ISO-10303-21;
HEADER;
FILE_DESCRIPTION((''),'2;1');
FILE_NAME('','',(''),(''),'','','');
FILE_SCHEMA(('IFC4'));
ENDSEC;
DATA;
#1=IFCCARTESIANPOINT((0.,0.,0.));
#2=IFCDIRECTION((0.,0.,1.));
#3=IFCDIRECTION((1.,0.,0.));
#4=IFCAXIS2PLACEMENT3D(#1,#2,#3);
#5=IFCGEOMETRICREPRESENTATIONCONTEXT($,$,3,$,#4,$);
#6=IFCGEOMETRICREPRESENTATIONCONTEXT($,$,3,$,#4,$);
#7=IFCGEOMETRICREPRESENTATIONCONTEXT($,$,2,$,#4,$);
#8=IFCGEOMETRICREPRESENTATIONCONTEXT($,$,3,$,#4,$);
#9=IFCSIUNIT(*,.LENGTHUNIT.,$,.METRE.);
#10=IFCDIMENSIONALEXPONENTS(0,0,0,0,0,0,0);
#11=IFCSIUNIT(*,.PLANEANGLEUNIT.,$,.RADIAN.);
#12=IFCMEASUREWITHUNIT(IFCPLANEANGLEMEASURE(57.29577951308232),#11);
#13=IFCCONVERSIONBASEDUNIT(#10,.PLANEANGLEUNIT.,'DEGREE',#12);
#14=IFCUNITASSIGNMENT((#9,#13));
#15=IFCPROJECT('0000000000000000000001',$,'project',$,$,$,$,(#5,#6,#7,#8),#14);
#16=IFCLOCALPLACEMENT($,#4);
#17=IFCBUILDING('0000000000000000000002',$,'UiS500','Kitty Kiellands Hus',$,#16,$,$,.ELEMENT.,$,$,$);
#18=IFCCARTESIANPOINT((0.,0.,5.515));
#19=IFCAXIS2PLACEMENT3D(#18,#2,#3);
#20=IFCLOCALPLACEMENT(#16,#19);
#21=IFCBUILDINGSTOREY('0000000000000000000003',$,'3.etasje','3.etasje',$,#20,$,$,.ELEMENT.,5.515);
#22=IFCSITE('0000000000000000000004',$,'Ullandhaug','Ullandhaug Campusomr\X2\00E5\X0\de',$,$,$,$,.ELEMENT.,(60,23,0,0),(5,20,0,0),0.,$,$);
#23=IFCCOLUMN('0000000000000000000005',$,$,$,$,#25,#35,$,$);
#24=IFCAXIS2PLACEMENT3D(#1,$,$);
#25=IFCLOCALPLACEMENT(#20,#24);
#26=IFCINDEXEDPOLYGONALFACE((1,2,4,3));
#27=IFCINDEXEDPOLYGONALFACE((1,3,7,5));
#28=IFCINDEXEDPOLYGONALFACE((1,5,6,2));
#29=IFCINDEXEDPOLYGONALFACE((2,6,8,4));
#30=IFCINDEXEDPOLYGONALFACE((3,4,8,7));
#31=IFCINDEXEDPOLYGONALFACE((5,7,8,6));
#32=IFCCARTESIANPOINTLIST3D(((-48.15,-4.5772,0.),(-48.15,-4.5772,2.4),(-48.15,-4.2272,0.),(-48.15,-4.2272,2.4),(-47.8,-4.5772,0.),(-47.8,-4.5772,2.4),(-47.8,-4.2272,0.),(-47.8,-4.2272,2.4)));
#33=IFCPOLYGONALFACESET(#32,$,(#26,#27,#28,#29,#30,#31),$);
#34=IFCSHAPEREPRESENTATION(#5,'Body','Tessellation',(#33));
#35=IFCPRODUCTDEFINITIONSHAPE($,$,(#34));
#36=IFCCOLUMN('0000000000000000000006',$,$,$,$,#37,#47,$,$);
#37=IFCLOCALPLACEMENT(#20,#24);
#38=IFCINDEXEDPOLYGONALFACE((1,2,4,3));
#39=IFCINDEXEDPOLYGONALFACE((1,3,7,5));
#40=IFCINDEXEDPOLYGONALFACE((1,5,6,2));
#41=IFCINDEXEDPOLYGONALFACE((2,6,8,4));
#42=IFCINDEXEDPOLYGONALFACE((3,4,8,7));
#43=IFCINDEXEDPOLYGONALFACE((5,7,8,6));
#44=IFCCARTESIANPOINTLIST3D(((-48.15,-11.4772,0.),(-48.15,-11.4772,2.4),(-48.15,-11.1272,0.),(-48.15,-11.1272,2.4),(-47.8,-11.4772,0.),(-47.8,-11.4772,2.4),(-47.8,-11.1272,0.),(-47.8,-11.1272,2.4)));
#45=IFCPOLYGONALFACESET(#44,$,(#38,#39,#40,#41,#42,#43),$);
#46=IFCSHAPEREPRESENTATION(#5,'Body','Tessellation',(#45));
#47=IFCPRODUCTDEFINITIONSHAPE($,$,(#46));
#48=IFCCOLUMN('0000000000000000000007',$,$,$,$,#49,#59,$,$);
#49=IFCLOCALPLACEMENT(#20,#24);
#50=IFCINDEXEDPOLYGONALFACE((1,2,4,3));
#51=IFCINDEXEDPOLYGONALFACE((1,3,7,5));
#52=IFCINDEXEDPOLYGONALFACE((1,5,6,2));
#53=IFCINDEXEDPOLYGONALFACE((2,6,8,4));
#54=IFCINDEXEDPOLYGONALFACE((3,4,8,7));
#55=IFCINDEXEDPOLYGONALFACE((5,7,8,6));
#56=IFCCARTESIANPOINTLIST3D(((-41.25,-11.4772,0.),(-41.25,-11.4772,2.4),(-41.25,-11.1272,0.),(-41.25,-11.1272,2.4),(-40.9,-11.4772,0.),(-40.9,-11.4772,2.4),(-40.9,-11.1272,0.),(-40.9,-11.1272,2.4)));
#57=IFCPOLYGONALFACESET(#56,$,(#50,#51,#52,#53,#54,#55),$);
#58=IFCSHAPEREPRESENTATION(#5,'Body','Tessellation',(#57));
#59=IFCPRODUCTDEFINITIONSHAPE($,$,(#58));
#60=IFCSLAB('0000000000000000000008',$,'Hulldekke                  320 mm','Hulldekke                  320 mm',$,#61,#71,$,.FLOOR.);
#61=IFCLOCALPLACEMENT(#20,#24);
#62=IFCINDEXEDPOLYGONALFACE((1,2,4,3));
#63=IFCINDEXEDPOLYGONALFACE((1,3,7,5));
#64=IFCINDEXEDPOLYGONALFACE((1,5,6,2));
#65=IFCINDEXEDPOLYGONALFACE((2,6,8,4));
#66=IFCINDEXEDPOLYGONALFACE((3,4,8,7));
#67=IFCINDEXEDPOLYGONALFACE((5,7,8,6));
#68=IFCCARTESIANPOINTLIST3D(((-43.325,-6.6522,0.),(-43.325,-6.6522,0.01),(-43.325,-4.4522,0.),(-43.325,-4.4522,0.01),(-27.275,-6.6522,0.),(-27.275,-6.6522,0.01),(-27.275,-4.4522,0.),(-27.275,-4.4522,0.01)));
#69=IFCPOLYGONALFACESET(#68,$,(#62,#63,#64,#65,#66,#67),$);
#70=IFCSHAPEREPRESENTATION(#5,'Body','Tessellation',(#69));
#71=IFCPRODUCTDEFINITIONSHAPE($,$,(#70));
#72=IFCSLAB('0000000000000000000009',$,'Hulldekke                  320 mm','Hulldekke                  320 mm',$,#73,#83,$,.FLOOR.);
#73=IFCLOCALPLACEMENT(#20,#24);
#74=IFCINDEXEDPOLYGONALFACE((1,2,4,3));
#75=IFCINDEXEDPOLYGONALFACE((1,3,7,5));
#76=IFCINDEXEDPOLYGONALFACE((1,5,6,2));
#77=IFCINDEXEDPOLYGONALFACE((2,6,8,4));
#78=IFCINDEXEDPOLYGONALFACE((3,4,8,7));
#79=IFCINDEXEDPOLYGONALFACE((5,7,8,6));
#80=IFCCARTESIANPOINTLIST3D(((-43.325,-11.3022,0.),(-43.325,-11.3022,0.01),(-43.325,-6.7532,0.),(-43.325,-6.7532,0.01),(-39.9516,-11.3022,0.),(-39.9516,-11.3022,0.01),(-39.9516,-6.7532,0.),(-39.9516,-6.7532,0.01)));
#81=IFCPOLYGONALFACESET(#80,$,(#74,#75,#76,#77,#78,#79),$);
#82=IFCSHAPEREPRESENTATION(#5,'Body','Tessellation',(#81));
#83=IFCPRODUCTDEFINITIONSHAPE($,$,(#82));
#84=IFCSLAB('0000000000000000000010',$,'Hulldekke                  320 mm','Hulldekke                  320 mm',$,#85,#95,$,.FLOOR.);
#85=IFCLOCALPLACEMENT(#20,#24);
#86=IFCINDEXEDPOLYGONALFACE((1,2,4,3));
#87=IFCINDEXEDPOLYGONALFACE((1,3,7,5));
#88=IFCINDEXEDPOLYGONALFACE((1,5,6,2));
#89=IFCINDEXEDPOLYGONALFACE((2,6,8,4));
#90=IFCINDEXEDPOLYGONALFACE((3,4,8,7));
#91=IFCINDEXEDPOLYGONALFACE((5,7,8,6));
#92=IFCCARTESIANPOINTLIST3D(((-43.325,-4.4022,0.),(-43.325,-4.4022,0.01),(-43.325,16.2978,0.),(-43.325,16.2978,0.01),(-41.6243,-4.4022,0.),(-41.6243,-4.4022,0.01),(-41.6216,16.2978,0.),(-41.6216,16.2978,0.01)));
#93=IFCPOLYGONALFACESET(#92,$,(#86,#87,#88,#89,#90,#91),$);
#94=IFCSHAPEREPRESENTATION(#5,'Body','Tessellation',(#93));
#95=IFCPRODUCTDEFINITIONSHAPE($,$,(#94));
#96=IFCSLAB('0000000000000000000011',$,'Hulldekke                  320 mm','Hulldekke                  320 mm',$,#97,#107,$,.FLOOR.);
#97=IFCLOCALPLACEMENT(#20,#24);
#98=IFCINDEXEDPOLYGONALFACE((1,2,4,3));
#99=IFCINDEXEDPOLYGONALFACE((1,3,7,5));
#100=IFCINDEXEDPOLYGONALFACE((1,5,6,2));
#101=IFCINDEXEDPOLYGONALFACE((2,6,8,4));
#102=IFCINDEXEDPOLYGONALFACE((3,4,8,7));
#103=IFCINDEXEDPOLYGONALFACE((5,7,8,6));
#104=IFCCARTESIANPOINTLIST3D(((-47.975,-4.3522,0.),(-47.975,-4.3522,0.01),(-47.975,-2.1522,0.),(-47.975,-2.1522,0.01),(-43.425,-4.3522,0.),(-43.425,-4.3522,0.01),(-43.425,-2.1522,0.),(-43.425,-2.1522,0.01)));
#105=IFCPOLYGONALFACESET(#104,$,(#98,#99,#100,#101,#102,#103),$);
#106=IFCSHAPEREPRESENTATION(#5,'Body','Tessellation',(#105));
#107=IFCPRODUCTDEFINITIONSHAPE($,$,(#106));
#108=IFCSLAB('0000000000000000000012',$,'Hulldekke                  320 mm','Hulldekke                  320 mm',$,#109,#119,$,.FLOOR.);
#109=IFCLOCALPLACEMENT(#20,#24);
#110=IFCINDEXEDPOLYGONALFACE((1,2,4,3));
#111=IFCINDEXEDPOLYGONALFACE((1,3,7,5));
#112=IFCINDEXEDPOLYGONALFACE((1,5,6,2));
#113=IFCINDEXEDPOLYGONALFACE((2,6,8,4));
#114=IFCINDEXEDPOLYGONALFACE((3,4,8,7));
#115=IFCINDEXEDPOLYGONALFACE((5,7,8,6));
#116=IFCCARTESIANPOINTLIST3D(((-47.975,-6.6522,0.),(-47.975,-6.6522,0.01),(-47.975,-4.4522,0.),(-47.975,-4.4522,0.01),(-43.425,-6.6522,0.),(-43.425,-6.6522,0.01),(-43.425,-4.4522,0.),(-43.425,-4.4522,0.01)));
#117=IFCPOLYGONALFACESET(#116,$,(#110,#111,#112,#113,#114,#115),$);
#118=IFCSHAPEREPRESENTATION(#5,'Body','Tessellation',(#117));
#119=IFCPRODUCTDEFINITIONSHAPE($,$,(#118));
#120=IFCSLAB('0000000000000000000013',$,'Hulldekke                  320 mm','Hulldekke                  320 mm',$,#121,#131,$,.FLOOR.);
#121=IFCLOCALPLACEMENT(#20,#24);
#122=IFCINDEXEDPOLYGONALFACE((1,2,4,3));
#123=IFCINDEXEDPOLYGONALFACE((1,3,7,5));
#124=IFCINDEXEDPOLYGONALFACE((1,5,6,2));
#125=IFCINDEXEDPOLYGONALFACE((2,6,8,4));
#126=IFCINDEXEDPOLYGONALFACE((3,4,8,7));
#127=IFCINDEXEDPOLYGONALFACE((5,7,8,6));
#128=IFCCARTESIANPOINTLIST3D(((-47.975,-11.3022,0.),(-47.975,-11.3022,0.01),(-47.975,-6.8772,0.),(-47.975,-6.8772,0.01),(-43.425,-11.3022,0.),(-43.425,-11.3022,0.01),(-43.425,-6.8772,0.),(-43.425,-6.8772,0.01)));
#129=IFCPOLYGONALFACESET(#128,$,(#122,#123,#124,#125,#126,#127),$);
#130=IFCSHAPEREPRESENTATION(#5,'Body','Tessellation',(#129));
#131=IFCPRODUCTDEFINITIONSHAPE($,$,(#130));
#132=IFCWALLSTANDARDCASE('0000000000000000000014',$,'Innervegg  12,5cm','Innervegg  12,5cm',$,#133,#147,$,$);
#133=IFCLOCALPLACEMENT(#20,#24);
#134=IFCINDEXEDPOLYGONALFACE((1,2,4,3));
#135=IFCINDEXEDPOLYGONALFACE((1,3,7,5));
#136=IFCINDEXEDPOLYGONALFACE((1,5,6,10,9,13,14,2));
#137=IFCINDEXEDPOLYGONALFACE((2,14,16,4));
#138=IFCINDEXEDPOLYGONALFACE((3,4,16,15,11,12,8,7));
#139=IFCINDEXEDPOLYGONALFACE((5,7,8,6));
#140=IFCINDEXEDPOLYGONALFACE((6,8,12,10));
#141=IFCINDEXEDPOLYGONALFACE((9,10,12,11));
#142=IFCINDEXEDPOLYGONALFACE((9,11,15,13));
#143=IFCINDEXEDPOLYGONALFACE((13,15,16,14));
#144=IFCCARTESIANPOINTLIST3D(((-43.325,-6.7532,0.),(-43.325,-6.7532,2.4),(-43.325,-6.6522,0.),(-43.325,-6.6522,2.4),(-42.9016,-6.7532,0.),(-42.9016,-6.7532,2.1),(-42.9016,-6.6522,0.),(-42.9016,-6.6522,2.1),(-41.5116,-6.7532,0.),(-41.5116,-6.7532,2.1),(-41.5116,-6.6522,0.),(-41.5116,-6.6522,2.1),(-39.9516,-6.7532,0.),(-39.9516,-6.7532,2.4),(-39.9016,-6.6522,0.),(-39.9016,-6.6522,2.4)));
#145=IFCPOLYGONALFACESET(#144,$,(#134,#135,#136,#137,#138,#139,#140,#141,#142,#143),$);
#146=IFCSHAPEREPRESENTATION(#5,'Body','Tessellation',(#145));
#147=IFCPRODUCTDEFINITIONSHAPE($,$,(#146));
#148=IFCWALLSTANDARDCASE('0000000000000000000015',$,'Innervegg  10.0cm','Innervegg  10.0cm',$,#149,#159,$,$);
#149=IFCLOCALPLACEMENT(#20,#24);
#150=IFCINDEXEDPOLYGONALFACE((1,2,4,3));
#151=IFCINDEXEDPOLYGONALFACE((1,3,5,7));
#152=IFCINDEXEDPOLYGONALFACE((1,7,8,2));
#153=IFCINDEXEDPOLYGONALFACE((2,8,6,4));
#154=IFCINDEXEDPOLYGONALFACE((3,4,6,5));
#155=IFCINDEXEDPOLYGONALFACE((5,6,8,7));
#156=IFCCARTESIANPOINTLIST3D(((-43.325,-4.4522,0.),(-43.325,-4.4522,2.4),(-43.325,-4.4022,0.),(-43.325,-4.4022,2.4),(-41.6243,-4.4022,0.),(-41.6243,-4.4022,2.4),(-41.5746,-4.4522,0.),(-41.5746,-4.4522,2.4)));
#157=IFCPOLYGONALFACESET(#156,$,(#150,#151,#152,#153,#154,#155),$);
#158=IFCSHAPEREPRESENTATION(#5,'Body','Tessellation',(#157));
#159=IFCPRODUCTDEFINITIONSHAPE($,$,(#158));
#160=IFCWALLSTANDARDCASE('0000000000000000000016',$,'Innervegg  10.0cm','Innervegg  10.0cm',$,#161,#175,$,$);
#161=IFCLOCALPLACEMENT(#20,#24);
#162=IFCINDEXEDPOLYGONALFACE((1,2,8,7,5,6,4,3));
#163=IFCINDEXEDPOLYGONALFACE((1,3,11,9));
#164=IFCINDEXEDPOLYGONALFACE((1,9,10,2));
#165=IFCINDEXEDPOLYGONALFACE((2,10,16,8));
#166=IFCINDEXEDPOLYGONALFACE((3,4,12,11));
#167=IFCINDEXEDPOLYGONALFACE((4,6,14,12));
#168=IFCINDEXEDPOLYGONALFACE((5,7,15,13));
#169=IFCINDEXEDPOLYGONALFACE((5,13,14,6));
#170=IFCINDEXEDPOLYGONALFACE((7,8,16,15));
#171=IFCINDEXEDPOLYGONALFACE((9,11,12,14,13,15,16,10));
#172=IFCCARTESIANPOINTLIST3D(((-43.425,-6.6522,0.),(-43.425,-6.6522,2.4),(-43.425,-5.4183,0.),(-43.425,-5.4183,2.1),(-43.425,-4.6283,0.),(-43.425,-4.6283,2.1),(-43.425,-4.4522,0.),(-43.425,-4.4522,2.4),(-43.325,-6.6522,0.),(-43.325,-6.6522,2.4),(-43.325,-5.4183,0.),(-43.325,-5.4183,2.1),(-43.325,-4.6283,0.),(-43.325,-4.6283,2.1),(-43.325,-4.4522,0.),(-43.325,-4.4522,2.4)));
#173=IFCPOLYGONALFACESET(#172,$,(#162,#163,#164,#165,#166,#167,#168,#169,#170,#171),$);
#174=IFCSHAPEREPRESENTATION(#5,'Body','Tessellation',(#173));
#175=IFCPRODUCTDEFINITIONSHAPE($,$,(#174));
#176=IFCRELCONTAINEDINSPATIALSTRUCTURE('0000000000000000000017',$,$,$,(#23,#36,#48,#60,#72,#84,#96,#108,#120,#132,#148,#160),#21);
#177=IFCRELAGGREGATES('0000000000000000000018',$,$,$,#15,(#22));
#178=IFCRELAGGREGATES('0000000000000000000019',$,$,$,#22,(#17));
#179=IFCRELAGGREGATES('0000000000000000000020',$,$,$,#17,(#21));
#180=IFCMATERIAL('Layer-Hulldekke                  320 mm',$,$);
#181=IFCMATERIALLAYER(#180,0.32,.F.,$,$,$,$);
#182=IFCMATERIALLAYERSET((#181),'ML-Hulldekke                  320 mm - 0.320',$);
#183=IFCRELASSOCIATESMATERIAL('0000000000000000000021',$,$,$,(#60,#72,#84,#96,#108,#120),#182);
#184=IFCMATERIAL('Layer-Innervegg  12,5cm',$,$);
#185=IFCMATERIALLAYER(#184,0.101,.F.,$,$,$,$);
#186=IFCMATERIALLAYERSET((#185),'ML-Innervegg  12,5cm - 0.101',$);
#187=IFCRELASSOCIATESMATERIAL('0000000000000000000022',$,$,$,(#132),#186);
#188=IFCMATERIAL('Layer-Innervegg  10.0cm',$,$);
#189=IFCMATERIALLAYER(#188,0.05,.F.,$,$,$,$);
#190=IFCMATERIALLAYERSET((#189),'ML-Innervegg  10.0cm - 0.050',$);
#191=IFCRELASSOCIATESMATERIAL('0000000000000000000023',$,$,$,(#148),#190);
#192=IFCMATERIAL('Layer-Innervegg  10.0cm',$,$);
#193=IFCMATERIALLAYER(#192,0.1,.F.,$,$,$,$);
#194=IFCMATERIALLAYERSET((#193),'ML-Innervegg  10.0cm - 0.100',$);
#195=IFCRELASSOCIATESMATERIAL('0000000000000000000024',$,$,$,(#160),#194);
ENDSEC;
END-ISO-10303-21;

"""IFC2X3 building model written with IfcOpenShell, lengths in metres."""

from ifc_helpers import new_model, entity, si_unit, converted_unit, frame, origin_with_axes, origin_2d_with_axis, place, context, project, spatial, polyline, rectangle, outline, extrude, material, layer, layer_set, layer_usage, element, save


model = new_model("IFC2X3")

# Units and contexts
context_of_model_1 = context(None, 3, world=origin_with_axes())
context_of_model_2 = context(None, 3, world=origin_with_axes())
context_of_model_3 = context(None, 2, world=origin_with_axes())
context_of_model_4 = context(None, 3, world=origin_with_axes())
ifc_project = project(units=[si_unit("LENGTHUNIT", "METRE"), converted_unit("PLANEANGLEUNIT", "DEGREE", entity("IfcPlaneAngleMeasure", 57.29577951308232), si_unit("PLANEANGLEUNIT", "RADIAN"), dimensions=[0, 0, 0, 0, 0, 0, 0])], contexts=[context_of_model_1, context_of_model_2, context_of_model_3, context_of_model_4])

# Site, building, storey
site = spatial("IfcSite", under=ifc_project, Name="Ullandhaug", Description="Ullandhaug Campusområde", CompositionType="ELEMENT", RefLatitude=(60, 23, 0, 0), RefLongitude=(5, 20, 0, 0), RefElevation=0.0)
building_placement = place(None, origin_with_axes())
building = spatial("IfcBuilding", under=site, at=building_placement, Name="UiS500", Description="Kitty Kiellands Hus", CompositionType="ELEMENT")
storey_placement = place(building_placement, frame((0.0, 0.0, 5.515), z_axis=(0.0, 0.0, 1.0), x_axis=(1.0, 0.0, 0.0)))
storey = spatial("IfcBuildingStorey", under=building, at=storey_placement, Name="3.etasje", Description="3.etasje", CompositionType="ELEMENT", Elevation=5.515)

# Columns
for number, where, z_axis, x_axis in (
    (1, (-47.975, -4.4022, 0.0), (0.0, 0.0, 1.0), (1.0, 0.0, 0.0)),
    (2, (-47.975, -11.3022, 0.0), (0.0, 0.0, 1.0), (1.0, 0.0, 0.0)),
    (3, (-41.075, -11.3022, 0.0), (0.0, 0.0, 1.0), (1.0, 0.0, 0.0)),
):
    element("IfcColumn", number, at=place(storey_placement, frame(where, z_axis=z_axis, x_axis=x_axis)), inside=storey, context=context_of_model_1, shape_type="SweptSolid", body=[
        extrude(rectangle(XDim=0.35, YDim=0.35, at=origin_2d_with_axis()), origin_with_axes(), (0.0, 0.0, 1.0), 2.4),
    ])

# Slabs
ifc_material_1 = material(Name="Layer-Hulldekke                  320 mm")
ifc_layer_1 = layer(ifc_material_1, 0.32, ventilated=False)
ifc_layer_set_1 = layer_set([ifc_layer_1], Name="ML-Hulldekke                  320 mm - 0.320")
ifc_layer_usage_1 = layer_usage(ifc_layer_set_1, "AXIS2", "POSITIVE", 0.0)
slab_1_placement = place(storey_placement, frame((-43.325, -6.6522, 0.0), z_axis=(0.0, 0.0, 1.0), x_axis=(1.0, 0.0, 0.0)))
element("IfcSlab", 4, at=slab_1_placement, inside=storey, material=ifc_layer_usage_1, Name="Hulldekke                  320 mm", Description="Hulldekke                  320 mm", PredefinedType="FLOOR", context=context_of_model_1, shape_type="SweptSolid", body=[
    extrude(outline(polyline([(0.0, 0.0), (16.05, 0.0), (16.05, 2.2), (0.0, 2.2), (0.0, 0.0)])), origin_with_axes(), (0.0, 0.0, 1.0), 0.01),
])
slab_2_placement = place(storey_placement, frame((-43.325, -11.3022, 0.0), z_axis=(0.0, 0.0, 1.0), x_axis=(1.0, 0.0, 0.0)))
element("IfcSlab", 5, at=slab_2_placement, inside=storey, material=ifc_layer_usage_1, Name="Hulldekke                  320 mm", Description="Hulldekke                  320 mm", PredefinedType="FLOOR", context=context_of_model_1, shape_type="SweptSolid", body=[
    extrude(outline(polyline([(0.0, 0.0), (3.3734, 0.0), (3.3734, 4.549), (0.0, 4.549), (0.0, 0.0)])), origin_with_axes(), (0.0, 0.0, 1.0), 0.01),
])
slab_3_placement = place(storey_placement, frame((-41.6243, -4.4022, 0.0), z_axis=(0.0, 0.0, 1.0), x_axis=(1.0, 0.0, 0.0)))
element("IfcSlab", 6, at=slab_3_placement, inside=storey, material=ifc_layer_usage_1, Name="Hulldekke                  320 mm", Description="Hulldekke                  320 mm", PredefinedType="FLOOR", context=context_of_model_1, shape_type="SweptSolid", body=[
    extrude(outline(polyline([(0.0, 0.0), (20.7, 0.0), (20.6998, 1.7034), (-0.0002, 1.7007), (0.0, 0.0)])), frame((0.0, 0.0, 0.0), z_axis=(0.0, 0.0, 1.0), x_axis=(0.000127, 1.0, 0.0)), (0.0, 0.0, 1.0), 0.01),
])
slab_4_placement = place(storey_placement, frame((-43.425, -4.3522, 0.0), z_axis=(0.0, 0.0, 1.0), x_axis=(1.0, 0.0, 0.0)))
element("IfcSlab", 7, at=slab_4_placement, inside=storey, material=ifc_layer_usage_1, Name="Hulldekke                  320 mm", Description="Hulldekke                  320 mm", PredefinedType="FLOOR", context=context_of_model_1, shape_type="SweptSolid", body=[
    extrude(outline(polyline([(0.0, 0.0), (2.2, 0.0), (2.2, 4.55), (0.0, 4.55), (0.0, 0.0)])), frame((0.0, 0.0, 0.0), z_axis=(0.0, 0.0, 1.0), x_axis=(0.0, 1.0, 0.0)), (0.0, 0.0, 1.0), 0.01),
])
slab_5_placement = place(storey_placement, frame((-47.975, -4.4522, 0.0), z_axis=(0.0, 0.0, 1.0), x_axis=(1.0, 0.0, 0.0)))
element("IfcSlab", 8, at=slab_5_placement, inside=storey, material=ifc_layer_usage_1, Name="Hulldekke                  320 mm", Description="Hulldekke                  320 mm", PredefinedType="FLOOR", context=context_of_model_1, shape_type="SweptSolid", body=[
    extrude(outline(polyline([(0.0, 0.0), (2.2, 0.0), (2.2, 4.55), (0.0, 4.55), (0.0, 0.0)])), frame((0.0, 0.0, 0.0), z_axis=(0.0, 0.0, 1.0), x_axis=(0.0, -1.0, 0.0)), (0.0, 0.0, 1.0), 0.01),
])
slab_6_placement = place(storey_placement, frame((-47.975, -6.8772, 0.0), z_axis=(0.0, 0.0, 1.0), x_axis=(1.0, 0.0, 0.0)))
element("IfcSlab", 9, at=slab_6_placement, inside=storey, material=ifc_layer_usage_1, Name="Hulldekke                  320 mm", Description="Hulldekke                  320 mm", PredefinedType="FLOOR", context=context_of_model_1, shape_type="SweptSolid", body=[
    extrude(outline(polyline([(0.0, 0.0), (4.425, 0.0), (4.425, 4.55), (0.0, 4.55), (0.0, 0.0)])), frame((0.0, 0.0, 0.0), z_axis=(0.0, 0.0, 1.0), x_axis=(0.0, -1.0, 0.0)), (0.0, 0.0, 1.0), 0.01),
])

# Wall, opening
ifc_material_2 = material(Name="Layer-Innervegg  12,5cm")
ifc_layer_2 = layer(ifc_material_2, 0.101, ventilated=False)
ifc_layer_set_2 = layer_set([ifc_layer_2], Name="ML-Innervegg  12,5cm - 0.101")
ifc_layer_usage_2 = layer_usage(ifc_layer_set_2, "AXIS2", "POSITIVE", 0.0)
wall_1_placement = place(storey_placement, frame((-43.325, -6.7532, 0.0), z_axis=(0.0, 0.0, 1.0), x_axis=(1.0, 0.0, 0.0)))
wall_1 = element("IfcWallStandardCase", 10, at=wall_1_placement, inside=storey, material=ifc_layer_usage_2, Name="Innervegg  12,5cm", Description="Innervegg  12,5cm", context=context_of_model_1, shape_type="SweptSolid", body=[
    extrude(outline(polyline([(0.0, 0.0), (3.3734, 0.0), (3.4234, 0.101), (0.0, 0.101), (0.0, 0.0)])), origin_with_axes(), (0.0, 0.0, 1.0), 2.4),
])
opening_1_placement = place(wall_1_placement, frame((0.4234, 0.101, 0.0), z_axis=(0.0, 0.0, 1.0), x_axis=(1.0, 0.0, 0.0)))
element("IfcOpeningElement", 11, at=opening_1_placement, cuts=wall_1, context=context_of_model_1, shape_type="SweptSolid", body=[
    extrude(outline(polyline([(0.0, 0.0), (2.1, 0.0), (2.1, 1.39), (0.0, 1.39), (0.0, 0.0)])), frame((0.0, 0.0, 0.0), z_axis=(0.0, 1.0, 0.0), x_axis=(0.0, 0.0, 1.0)), (0.0, 0.0, -1.0), 0.101),
])

# Wall
ifc_material_3 = material(Name="Layer-Innervegg  10.0cm")
ifc_layer_3 = layer(ifc_material_3, 0.05, ventilated=False)
ifc_layer_set_3 = layer_set([ifc_layer_3], Name="ML-Innervegg  10.0cm - 0.050")
ifc_layer_usage_3 = layer_usage(ifc_layer_set_3, "AXIS2", "POSITIVE", 0.0)
wall_2_placement = place(storey_placement, frame((-41.6243, -4.4022, 0.0), z_axis=(0.0, 0.0, 1.0), x_axis=(-1.0, 0.0, 0.0)))
element("IfcWallStandardCase", 12, at=wall_2_placement, inside=storey, material=ifc_layer_usage_3, Name="Innervegg  10.0cm", Description="Innervegg  10.0cm", context=context_of_model_1, shape_type="SweptSolid", body=[
    extrude(outline(polyline([(0.0, 0.0), (1.7007, 0.0), (1.7007, 0.05), (-0.0496, 0.05), (0.0, 0.0)])), frame((0.0, 0.0, 0.0), z_axis=(0.0, 0.0, 1.0), x_axis=(1.0, 0.0, 0.0)), (0.0, 0.0, 1.0), 2.4),
])

# Wall, opening
ifc_material_4 = material(Name="Layer-Innervegg  10.0cm")
ifc_layer_4 = layer(ifc_material_4, 0.1, ventilated=False)
ifc_layer_set_4 = layer_set([ifc_layer_4], Name="ML-Innervegg  10.0cm - 0.100")
ifc_layer_usage_4 = layer_usage(ifc_layer_set_4, "AXIS2", "POSITIVE", 0.0)
wall_3_placement = place(storey_placement, frame((-43.425, -4.4522, 0.0), z_axis=(0.0, 0.0, 1.0), x_axis=(0.0, -1.0, 0.0)))
wall_3 = element("IfcWallStandardCase", 13, at=wall_3_placement, inside=storey, material=ifc_layer_usage_4, Name="Innervegg  10.0cm", Description="Innervegg  10.0cm", context=context_of_model_1, shape_type="SweptSolid", body=[
    extrude(outline(polyline([(0.0, 0.0), (2.2, 0.0), (2.2, 0.1), (0.0, 0.1), (0.0, 0.0)])), frame((0.0, 0.0, 0.0), z_axis=(0.0, 0.0, 1.0), x_axis=(1.0, 0.0, 0.0)), (0.0, 0.0, 1.0), 2.4),
])
opening_2_placement = place(wall_3_placement, frame((0.176, 0.1, 0.0), z_axis=(0.0, 0.0, 1.0), x_axis=(1.0, 0.0, 0.0)))
element("IfcOpeningElement", 14, at=opening_2_placement, cuts=wall_3, context=context_of_model_1, shape_type="SweptSolid", body=[
    extrude(outline(polyline([(0.0, 0.0), (2.1, 0.0), (2.1, 0.79), (0.0, 0.79), (0.0, 0.0)])), frame((0.0, 0.0, 0.0), z_axis=(0.0, 1.0, 0.0), x_axis=(0.0, 0.0, 1.0)), (0.0, 0.0, -1.0), 0.1),
])

save(model, "model.ifc")
